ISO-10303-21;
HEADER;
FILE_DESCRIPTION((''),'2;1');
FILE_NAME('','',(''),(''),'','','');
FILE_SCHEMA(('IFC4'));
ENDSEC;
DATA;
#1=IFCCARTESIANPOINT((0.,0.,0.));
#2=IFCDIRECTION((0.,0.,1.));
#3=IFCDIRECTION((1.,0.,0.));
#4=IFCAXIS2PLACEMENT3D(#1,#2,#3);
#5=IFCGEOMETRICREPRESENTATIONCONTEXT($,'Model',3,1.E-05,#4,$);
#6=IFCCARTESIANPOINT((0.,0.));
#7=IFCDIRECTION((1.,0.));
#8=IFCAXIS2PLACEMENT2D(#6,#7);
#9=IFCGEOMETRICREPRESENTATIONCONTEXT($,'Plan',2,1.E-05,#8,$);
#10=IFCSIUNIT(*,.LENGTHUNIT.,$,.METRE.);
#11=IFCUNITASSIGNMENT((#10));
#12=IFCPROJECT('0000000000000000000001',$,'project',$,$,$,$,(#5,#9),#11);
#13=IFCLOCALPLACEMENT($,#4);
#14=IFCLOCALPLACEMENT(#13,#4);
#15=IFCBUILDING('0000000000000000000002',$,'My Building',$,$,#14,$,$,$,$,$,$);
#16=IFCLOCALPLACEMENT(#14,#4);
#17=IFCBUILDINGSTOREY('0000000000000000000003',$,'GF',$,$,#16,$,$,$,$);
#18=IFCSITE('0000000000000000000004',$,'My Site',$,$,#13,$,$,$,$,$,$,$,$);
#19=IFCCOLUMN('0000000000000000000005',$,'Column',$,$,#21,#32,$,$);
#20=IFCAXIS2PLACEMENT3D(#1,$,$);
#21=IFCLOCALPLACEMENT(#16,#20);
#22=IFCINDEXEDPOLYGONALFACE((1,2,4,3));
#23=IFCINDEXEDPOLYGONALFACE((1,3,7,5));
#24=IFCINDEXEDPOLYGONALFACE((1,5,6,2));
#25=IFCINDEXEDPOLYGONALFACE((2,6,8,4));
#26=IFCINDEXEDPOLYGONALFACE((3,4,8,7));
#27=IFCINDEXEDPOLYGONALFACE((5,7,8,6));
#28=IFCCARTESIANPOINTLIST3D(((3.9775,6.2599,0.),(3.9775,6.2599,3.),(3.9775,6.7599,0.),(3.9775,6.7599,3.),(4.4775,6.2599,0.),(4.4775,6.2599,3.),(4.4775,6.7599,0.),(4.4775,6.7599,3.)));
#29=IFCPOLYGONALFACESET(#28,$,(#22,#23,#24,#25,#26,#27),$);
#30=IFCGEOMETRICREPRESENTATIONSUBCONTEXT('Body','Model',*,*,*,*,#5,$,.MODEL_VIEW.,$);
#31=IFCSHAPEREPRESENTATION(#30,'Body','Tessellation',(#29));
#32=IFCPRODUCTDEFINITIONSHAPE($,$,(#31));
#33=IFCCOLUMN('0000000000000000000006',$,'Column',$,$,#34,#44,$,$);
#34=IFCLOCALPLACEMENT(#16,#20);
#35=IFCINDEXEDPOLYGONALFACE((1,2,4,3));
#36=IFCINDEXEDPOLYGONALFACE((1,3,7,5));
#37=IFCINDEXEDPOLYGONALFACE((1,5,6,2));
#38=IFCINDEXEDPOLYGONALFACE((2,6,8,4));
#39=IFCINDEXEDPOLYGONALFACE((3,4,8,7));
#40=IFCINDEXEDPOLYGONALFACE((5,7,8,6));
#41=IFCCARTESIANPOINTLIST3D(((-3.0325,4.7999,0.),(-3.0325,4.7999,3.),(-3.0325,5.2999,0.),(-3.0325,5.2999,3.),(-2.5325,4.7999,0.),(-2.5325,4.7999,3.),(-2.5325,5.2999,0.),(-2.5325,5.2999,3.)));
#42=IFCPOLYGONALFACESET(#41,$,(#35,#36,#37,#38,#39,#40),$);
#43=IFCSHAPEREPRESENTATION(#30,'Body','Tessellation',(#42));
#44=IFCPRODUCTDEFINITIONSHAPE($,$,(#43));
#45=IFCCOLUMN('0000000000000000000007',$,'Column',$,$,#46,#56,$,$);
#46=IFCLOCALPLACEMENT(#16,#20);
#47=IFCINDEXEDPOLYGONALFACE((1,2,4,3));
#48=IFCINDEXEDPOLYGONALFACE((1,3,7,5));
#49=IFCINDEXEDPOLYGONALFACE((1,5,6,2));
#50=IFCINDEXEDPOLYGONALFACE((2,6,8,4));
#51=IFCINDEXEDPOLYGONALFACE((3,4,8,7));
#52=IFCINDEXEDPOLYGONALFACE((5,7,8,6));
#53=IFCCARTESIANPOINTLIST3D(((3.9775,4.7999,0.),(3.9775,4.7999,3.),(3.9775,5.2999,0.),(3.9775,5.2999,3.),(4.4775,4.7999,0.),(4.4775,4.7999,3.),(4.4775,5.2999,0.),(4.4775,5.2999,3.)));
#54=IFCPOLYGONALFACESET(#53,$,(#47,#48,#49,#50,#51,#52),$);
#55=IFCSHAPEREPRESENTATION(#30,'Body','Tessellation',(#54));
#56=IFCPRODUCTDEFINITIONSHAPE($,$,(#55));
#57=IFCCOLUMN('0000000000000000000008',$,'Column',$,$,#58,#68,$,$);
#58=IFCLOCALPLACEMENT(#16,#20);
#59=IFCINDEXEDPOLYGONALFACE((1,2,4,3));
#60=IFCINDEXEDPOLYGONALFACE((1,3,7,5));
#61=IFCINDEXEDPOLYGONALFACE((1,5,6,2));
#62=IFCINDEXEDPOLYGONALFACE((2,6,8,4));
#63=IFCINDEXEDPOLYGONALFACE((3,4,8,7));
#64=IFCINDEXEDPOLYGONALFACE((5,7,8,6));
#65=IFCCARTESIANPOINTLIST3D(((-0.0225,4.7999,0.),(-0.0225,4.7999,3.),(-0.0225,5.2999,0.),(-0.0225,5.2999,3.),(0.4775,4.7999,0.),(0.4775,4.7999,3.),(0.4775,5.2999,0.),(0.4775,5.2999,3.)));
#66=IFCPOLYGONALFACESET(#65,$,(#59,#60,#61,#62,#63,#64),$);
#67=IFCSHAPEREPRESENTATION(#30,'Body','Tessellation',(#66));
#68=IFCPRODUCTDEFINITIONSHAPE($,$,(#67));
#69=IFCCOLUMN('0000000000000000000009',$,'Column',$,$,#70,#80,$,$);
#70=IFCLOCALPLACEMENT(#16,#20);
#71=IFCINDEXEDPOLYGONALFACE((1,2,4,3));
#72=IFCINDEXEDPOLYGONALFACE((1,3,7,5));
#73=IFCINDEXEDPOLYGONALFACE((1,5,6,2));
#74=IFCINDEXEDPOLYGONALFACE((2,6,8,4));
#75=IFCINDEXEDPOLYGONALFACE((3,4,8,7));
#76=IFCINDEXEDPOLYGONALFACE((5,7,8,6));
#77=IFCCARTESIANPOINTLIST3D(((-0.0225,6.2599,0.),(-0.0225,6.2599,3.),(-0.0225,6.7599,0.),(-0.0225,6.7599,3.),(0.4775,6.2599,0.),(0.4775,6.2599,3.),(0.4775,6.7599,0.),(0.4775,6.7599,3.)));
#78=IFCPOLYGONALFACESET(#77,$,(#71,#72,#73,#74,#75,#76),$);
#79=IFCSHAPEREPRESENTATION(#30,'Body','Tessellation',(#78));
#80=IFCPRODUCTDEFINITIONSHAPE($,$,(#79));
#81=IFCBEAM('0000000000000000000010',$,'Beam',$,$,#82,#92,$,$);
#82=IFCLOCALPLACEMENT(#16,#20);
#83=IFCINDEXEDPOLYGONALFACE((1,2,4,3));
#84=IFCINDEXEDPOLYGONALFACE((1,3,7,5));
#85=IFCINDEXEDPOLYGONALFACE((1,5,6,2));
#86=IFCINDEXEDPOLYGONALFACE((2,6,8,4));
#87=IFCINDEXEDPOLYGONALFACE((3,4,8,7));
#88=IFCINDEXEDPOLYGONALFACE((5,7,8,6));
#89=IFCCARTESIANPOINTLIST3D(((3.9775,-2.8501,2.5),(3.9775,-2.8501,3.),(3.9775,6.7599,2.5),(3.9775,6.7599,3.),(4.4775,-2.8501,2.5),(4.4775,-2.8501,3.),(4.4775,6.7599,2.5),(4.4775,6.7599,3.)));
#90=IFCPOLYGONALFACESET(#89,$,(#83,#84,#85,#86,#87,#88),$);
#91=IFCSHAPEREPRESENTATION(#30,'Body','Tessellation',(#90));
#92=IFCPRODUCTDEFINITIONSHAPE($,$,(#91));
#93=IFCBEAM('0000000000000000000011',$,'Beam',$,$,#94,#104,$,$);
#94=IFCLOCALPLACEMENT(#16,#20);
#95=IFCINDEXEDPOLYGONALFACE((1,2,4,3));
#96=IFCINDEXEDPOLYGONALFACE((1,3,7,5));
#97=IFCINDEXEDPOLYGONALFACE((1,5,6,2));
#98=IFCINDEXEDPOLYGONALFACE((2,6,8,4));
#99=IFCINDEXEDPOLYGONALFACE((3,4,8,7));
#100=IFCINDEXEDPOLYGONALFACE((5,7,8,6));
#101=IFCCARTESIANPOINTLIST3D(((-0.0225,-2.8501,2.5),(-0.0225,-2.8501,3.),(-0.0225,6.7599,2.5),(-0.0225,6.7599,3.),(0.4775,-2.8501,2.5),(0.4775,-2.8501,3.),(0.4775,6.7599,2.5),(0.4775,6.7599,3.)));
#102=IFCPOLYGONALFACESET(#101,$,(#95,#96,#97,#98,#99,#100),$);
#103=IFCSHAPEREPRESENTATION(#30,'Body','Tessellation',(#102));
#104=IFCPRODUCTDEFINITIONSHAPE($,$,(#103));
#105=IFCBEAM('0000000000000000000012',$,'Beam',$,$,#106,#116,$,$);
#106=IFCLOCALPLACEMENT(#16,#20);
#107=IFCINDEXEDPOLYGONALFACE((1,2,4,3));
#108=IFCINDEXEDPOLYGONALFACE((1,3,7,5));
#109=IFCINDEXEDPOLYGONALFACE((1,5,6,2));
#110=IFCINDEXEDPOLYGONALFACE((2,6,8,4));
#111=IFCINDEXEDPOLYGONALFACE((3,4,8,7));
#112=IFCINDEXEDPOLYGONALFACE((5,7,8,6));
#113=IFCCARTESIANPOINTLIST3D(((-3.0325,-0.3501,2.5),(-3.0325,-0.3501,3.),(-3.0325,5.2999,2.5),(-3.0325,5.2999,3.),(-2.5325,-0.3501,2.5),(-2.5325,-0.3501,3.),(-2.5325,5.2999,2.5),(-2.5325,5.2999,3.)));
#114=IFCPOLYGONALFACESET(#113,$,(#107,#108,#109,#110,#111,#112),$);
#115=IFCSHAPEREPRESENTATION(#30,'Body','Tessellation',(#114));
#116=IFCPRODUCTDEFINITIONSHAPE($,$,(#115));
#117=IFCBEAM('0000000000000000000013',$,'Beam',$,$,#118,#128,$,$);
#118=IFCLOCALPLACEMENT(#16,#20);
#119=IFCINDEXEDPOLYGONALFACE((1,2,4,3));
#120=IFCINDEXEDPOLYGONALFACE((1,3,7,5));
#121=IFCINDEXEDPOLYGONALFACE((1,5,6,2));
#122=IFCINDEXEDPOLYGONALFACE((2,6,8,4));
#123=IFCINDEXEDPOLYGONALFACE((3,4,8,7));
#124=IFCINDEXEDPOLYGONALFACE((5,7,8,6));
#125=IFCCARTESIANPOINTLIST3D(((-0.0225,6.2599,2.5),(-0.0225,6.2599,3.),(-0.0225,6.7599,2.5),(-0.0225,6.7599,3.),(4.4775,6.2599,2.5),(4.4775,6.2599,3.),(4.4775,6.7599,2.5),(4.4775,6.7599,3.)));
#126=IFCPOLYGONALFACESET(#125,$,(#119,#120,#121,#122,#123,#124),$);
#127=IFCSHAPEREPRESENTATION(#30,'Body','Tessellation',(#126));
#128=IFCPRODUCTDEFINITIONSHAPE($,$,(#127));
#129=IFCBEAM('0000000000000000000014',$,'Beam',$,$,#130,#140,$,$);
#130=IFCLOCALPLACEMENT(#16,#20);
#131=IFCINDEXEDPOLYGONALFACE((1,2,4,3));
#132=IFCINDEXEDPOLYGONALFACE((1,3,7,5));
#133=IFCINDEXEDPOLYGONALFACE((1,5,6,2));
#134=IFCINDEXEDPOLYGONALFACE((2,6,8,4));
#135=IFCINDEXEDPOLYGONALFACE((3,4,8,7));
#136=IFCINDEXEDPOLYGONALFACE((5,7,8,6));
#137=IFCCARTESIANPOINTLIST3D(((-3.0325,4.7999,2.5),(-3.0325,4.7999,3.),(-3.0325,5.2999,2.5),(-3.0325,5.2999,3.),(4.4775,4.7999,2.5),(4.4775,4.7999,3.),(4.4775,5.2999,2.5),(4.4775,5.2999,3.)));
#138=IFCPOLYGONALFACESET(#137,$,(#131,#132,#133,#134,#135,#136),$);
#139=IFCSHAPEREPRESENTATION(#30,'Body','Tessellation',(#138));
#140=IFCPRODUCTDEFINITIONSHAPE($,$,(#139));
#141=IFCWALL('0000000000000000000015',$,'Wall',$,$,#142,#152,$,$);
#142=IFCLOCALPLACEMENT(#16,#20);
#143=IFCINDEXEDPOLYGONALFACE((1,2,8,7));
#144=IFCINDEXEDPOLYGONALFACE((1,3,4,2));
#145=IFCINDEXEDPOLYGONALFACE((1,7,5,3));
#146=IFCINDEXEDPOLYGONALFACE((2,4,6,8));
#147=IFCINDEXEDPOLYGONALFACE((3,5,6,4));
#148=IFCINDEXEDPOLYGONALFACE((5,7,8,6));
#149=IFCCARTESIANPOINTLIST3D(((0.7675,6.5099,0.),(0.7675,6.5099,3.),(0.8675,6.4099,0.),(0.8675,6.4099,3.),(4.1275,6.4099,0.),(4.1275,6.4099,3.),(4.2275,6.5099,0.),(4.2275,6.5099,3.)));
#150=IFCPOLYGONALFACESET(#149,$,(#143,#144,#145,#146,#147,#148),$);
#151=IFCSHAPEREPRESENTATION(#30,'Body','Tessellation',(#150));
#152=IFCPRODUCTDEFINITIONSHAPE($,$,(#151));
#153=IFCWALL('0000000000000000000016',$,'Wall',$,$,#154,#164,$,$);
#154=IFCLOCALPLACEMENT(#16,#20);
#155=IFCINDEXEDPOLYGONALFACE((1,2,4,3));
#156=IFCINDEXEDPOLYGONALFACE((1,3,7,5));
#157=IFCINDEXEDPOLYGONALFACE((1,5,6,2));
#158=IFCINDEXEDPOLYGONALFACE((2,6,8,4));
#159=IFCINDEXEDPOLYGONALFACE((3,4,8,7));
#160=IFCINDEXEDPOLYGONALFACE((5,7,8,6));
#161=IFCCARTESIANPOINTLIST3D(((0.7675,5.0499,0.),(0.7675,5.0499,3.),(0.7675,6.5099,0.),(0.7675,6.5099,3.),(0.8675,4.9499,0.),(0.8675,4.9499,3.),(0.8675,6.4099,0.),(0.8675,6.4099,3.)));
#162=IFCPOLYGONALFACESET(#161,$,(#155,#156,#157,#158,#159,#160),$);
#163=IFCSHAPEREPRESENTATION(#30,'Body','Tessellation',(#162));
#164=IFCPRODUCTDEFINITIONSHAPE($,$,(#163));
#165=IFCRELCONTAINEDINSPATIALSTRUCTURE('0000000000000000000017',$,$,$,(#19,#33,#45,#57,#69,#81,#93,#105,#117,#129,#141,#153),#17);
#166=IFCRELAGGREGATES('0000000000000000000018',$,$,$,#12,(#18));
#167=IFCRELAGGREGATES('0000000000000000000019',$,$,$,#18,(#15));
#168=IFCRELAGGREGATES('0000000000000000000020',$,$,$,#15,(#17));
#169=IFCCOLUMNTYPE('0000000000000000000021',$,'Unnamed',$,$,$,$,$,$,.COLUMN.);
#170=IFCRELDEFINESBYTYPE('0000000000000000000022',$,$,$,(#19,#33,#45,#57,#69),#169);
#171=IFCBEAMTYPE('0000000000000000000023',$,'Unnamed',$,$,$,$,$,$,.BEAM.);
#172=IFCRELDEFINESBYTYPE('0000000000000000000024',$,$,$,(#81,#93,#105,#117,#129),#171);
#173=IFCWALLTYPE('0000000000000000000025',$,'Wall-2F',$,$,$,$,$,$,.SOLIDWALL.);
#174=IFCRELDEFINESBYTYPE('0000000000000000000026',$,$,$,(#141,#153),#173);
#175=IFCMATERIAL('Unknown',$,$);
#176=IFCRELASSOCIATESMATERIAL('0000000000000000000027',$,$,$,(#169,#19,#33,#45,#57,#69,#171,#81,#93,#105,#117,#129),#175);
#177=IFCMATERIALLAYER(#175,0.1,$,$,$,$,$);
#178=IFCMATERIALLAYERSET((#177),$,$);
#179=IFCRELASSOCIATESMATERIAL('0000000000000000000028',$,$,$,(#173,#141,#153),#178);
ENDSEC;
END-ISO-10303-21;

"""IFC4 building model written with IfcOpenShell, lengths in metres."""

from ifc_helpers import new_model, si_unit, frame, origin_with_axes, origin_2d_with_axis, place, context, subcontext, project, spatial, line, indexed_curve, rectangle, outline, extrude, material, layer, layer_set, layer_usage, material_profile, profile_set, profile_usage, type_object, element, save


model = new_model("IFC4")

# Units and contexts
model_context = context("Model", 3, precision=1e-05, world=origin_with_axes())
plan_context = context("Plan", 2, precision=1e-05, world=origin_2d_with_axis())
body_context_1 = subcontext(model_context, "Body", "Model", "MODEL_VIEW")
ifc_project = project(units=[si_unit("LENGTHUNIT", "METRE")], contexts=[model_context, plan_context])

# Site, building, storey
site_placement = place(None, origin_with_axes())
site = spatial("IfcSite", under=ifc_project, at=site_placement, Name="My Site")
building_placement = place(site_placement, origin_with_axes())
building = spatial("IfcBuilding", under=site, at=building_placement, Name="My Building")
storey_placement = place(building_placement, origin_with_axes())
storey = spatial("IfcBuildingStorey", under=building, at=storey_placement, Name="GF")

# Columns
ifc_material_1 = material(Name="Unknown")
ifc_material_profile_1 = material_profile(ifc_material_1, rectangle(XDim=0.5, YDim=0.5))
ifc_profile_set_1 = profile_set([ifc_material_profile_1])
ifc_profile_usage_1 = profile_usage(ifc_profile_set_1, cardinal=5)
column_type = type_object("IfcColumnType", Name="Unnamed", PredefinedType="COLUMN", material=ifc_profile_set_1)
column_1_placement = place(storey_placement, frame((4.2275, 6.5099, 0.0), z_axis=(0.0, 0.0, 1.0), x_axis=(1.0, 0.0, 0.0)))
element("IfcColumn", 1, at=column_1_placement, inside=storey, type_object=column_type, material=ifc_profile_usage_1, Name="Column", context=body_context_1, shape_type="SweptSolid", body=[
    extrude(rectangle(XDim=0.5, YDim=0.5), origin_with_axes(), (0.0, 0.0, 1.0), 3.0),
])
ifc_profile_usage_2 = profile_usage(ifc_profile_set_1, cardinal=5)
column_2_placement = place(storey_placement, frame((-2.7825, 5.0499, 0.0), z_axis=(0.0, 0.0, 1.0), x_axis=(1.0, 0.0, 0.0)))
element("IfcColumn", 2, at=column_2_placement, inside=storey, type_object=column_type, material=ifc_profile_usage_2, Name="Column", context=body_context_1, shape_type="SweptSolid", body=[
    extrude(rectangle(XDim=0.5, YDim=0.5), origin_with_axes(), (0.0, 0.0, 1.0), 3.0),
])
ifc_profile_usage_3 = profile_usage(ifc_profile_set_1, cardinal=5)
column_3_placement = place(storey_placement, frame((4.2275, 5.0499, 0.0), z_axis=(0.0, 0.0, 1.0), x_axis=(1.0, 0.0, 0.0)))
element("IfcColumn", 3, at=column_3_placement, inside=storey, type_object=column_type, material=ifc_profile_usage_3, Name="Column", context=body_context_1, shape_type="SweptSolid", body=[
    extrude(rectangle(XDim=0.5, YDim=0.5), origin_with_axes(), (0.0, 0.0, 1.0), 3.0),
])
ifc_profile_usage_4 = profile_usage(ifc_profile_set_1, cardinal=5)
column_4_placement = place(storey_placement, frame((0.2275, 5.0499, 0.0), z_axis=(0.0, 0.0, 1.0), x_axis=(1.0, 0.0, 0.0)))
element("IfcColumn", 4, at=column_4_placement, inside=storey, type_object=column_type, material=ifc_profile_usage_4, Name="Column", context=body_context_1, shape_type="SweptSolid", body=[
    extrude(rectangle(XDim=0.5, YDim=0.5), origin_with_axes(), (0.0, 0.0, 1.0), 3.0),
])
ifc_profile_usage_5 = profile_usage(ifc_profile_set_1, cardinal=5)
column_5_placement = place(storey_placement, frame((0.2275, 6.5099, 0.0), z_axis=(0.0, 0.0, 1.0), x_axis=(1.0, 0.0, 0.0)))
element("IfcColumn", 5, at=column_5_placement, inside=storey, type_object=column_type, material=ifc_profile_usage_5, Name="Column", context=body_context_1, shape_type="SweptSolid", body=[
    extrude(rectangle(XDim=0.5, YDim=0.5), origin_with_axes(), (0.0, 0.0, 1.0), 3.0),
])

# Beams
ifc_material_profile_2 = material_profile(ifc_material_1, rectangle(XDim=0.5, YDim=0.5))
ifc_profile_set_2 = profile_set([ifc_material_profile_2])
ifc_profile_usage_6 = profile_usage(ifc_profile_set_2, cardinal=7)
beam_type = type_object("IfcBeamType", Name="Unnamed", PredefinedType="BEAM", material=ifc_profile_set_2)
beam_1_placement = place(storey_placement, frame((4.4775, 6.7599, 3.0), z_axis=(0.0, -1.0, 0.0), x_axis=(1.0, 0.0, 0.0)))
element("IfcBeam", 6, at=beam_1_placement, inside=storey, type_object=beam_type, material=ifc_profile_usage_6, Name="Beam", context=body_context_1, shape_type="SweptSolid", body=[
    extrude(rectangle(XDim=0.5, YDim=0.5), frame((-0.25, -0.25, 0.0), z_axis=(0.0, 0.0, 1.0), x_axis=(1.0, 0.0, 0.0)), (0.0, 0.0, 1.0), 9.61),
])
ifc_profile_usage_7 = profile_usage(ifc_profile_set_2, cardinal=7)
beam_2_placement = place(storey_placement, frame((0.4775, 6.7599, 3.0), z_axis=(0.0, -1.0, 0.0), x_axis=(1.0, 0.0, 0.0)))
element("IfcBeam", 7, at=beam_2_placement, inside=storey, type_object=beam_type, material=ifc_profile_usage_7, Name="Beam", context=body_context_1, shape_type="SweptSolid", body=[
    extrude(rectangle(XDim=0.5, YDim=0.5), frame((-0.25, -0.25, 0.0), z_axis=(0.0, 0.0, 1.0), x_axis=(1.0, 0.0, 0.0)), (0.0, 0.0, 1.0), 9.61),
])
ifc_profile_usage_8 = profile_usage(ifc_profile_set_2, cardinal=7)
beam_3_placement = place(storey_placement, frame((-2.5325, 5.2999, 3.0), z_axis=(0.0, -1.0, 0.0), x_axis=(1.0, 0.0, 0.0)))
element("IfcBeam", 8, at=beam_3_placement, inside=storey, type_object=beam_type, material=ifc_profile_usage_8, Name="Beam", context=body_context_1, shape_type="SweptSolid", body=[
    extrude(rectangle(XDim=0.5, YDim=0.5), frame((-0.25, -0.25, 0.0), z_axis=(0.0, 0.0, 1.0), x_axis=(1.0, 0.0, 0.0)), (0.0, 0.0, 1.0), 5.65),
])
ifc_profile_usage_9 = profile_usage(ifc_profile_set_2, cardinal=7)
beam_4_placement = place(storey_placement, frame((4.4775, 6.2599, 3.0), z_axis=(-1.0, -0.000001, 0.000001), x_axis=(0.000001, -1.0, 0.0)))
element("IfcBeam", 9, at=beam_4_placement, inside=storey, type_object=beam_type, material=ifc_profile_usage_9, Name="Beam", context=body_context_1, shape_type="SweptSolid", body=[
    extrude(rectangle(XDim=0.5, YDim=0.5), frame((-0.25, -0.25, 0.0), z_axis=(0.0, 0.0, 1.0), x_axis=(1.0, 0.0, 0.0)), (0.0, 0.0, 1.0), 4.5),
])
ifc_profile_usage_10 = profile_usage(ifc_profile_set_2, cardinal=7)
beam_5_placement = place(storey_placement, frame((-3.0325, 5.2999, 3.0), z_axis=(1.0, 0.0, 0.0), x_axis=(0.0, 1.0, 0.0)))
element("IfcBeam", 10, at=beam_5_placement, inside=storey, type_object=beam_type, material=ifc_profile_usage_10, Name="Beam", context=body_context_1, shape_type="SweptSolid", body=[
    extrude(rectangle(XDim=0.5, YDim=0.5), frame((-0.25, -0.25, 0.0), z_axis=(0.0, 0.0, 1.0), x_axis=(1.0, 0.0, 0.0)), (0.0, 0.0, 1.0), 7.51),
])

# Walls
ifc_layer_1 = layer(ifc_material_1, 0.1)
ifc_layer_set_1 = layer_set([ifc_layer_1])
ifc_layer_usage_1 = layer_usage(ifc_layer_set_1, "AXIS2", "POSITIVE", 0.0)
wall_type = type_object("IfcWallType", Name="Wall-2F", PredefinedType="SOLIDWALL", material=ifc_layer_set_1)
wall_1_placement = place(storey_placement, frame((4.2275, 6.5099, 0.0), z_axis=(0.0, 0.0, 1.0), x_axis=(-1.0, 0.0, 0.0)))
element("IfcWall", 11, at=wall_1_placement, inside=storey, type_object=wall_type, material=ifc_layer_usage_1, Name="Wall", context=body_context_1, shape_type="SweptSolid", body=[
    extrude(outline(indexed_curve([(0.0, 0.0), (0.1, 0.1), (3.36, 0.1), (3.46, 0.0)], segments=[line(1, 2, 3, 4, 1)])), origin_with_axes(), (0.0, 0.0, 1.0), 3.0),
])
ifc_layer_usage_2 = layer_usage(ifc_layer_set_1, "AXIS2", "POSITIVE", 0.0)
wall_2_placement = place(storey_placement, frame((0.7675, 6.5099, 0.0), z_axis=(0.0, 0.0, 1.0), x_axis=(0.0, -1.0, 0.0)))
element("IfcWall", 12, at=wall_2_placement, inside=storey, type_object=wall_type, material=ifc_layer_usage_2, Name="Wall", context=body_context_1, shape_type="SweptSolid", body=[
    extrude(outline(indexed_curve([(0.0, 0.0), (0.1, 0.1), (1.56, 0.1), (1.46, 0.0)], segments=[line(1, 2, 3, 4, 1)])), origin_with_axes(), (0.0, 0.0, 1.0), 3.0),
])

save(model, "model.ifc")
